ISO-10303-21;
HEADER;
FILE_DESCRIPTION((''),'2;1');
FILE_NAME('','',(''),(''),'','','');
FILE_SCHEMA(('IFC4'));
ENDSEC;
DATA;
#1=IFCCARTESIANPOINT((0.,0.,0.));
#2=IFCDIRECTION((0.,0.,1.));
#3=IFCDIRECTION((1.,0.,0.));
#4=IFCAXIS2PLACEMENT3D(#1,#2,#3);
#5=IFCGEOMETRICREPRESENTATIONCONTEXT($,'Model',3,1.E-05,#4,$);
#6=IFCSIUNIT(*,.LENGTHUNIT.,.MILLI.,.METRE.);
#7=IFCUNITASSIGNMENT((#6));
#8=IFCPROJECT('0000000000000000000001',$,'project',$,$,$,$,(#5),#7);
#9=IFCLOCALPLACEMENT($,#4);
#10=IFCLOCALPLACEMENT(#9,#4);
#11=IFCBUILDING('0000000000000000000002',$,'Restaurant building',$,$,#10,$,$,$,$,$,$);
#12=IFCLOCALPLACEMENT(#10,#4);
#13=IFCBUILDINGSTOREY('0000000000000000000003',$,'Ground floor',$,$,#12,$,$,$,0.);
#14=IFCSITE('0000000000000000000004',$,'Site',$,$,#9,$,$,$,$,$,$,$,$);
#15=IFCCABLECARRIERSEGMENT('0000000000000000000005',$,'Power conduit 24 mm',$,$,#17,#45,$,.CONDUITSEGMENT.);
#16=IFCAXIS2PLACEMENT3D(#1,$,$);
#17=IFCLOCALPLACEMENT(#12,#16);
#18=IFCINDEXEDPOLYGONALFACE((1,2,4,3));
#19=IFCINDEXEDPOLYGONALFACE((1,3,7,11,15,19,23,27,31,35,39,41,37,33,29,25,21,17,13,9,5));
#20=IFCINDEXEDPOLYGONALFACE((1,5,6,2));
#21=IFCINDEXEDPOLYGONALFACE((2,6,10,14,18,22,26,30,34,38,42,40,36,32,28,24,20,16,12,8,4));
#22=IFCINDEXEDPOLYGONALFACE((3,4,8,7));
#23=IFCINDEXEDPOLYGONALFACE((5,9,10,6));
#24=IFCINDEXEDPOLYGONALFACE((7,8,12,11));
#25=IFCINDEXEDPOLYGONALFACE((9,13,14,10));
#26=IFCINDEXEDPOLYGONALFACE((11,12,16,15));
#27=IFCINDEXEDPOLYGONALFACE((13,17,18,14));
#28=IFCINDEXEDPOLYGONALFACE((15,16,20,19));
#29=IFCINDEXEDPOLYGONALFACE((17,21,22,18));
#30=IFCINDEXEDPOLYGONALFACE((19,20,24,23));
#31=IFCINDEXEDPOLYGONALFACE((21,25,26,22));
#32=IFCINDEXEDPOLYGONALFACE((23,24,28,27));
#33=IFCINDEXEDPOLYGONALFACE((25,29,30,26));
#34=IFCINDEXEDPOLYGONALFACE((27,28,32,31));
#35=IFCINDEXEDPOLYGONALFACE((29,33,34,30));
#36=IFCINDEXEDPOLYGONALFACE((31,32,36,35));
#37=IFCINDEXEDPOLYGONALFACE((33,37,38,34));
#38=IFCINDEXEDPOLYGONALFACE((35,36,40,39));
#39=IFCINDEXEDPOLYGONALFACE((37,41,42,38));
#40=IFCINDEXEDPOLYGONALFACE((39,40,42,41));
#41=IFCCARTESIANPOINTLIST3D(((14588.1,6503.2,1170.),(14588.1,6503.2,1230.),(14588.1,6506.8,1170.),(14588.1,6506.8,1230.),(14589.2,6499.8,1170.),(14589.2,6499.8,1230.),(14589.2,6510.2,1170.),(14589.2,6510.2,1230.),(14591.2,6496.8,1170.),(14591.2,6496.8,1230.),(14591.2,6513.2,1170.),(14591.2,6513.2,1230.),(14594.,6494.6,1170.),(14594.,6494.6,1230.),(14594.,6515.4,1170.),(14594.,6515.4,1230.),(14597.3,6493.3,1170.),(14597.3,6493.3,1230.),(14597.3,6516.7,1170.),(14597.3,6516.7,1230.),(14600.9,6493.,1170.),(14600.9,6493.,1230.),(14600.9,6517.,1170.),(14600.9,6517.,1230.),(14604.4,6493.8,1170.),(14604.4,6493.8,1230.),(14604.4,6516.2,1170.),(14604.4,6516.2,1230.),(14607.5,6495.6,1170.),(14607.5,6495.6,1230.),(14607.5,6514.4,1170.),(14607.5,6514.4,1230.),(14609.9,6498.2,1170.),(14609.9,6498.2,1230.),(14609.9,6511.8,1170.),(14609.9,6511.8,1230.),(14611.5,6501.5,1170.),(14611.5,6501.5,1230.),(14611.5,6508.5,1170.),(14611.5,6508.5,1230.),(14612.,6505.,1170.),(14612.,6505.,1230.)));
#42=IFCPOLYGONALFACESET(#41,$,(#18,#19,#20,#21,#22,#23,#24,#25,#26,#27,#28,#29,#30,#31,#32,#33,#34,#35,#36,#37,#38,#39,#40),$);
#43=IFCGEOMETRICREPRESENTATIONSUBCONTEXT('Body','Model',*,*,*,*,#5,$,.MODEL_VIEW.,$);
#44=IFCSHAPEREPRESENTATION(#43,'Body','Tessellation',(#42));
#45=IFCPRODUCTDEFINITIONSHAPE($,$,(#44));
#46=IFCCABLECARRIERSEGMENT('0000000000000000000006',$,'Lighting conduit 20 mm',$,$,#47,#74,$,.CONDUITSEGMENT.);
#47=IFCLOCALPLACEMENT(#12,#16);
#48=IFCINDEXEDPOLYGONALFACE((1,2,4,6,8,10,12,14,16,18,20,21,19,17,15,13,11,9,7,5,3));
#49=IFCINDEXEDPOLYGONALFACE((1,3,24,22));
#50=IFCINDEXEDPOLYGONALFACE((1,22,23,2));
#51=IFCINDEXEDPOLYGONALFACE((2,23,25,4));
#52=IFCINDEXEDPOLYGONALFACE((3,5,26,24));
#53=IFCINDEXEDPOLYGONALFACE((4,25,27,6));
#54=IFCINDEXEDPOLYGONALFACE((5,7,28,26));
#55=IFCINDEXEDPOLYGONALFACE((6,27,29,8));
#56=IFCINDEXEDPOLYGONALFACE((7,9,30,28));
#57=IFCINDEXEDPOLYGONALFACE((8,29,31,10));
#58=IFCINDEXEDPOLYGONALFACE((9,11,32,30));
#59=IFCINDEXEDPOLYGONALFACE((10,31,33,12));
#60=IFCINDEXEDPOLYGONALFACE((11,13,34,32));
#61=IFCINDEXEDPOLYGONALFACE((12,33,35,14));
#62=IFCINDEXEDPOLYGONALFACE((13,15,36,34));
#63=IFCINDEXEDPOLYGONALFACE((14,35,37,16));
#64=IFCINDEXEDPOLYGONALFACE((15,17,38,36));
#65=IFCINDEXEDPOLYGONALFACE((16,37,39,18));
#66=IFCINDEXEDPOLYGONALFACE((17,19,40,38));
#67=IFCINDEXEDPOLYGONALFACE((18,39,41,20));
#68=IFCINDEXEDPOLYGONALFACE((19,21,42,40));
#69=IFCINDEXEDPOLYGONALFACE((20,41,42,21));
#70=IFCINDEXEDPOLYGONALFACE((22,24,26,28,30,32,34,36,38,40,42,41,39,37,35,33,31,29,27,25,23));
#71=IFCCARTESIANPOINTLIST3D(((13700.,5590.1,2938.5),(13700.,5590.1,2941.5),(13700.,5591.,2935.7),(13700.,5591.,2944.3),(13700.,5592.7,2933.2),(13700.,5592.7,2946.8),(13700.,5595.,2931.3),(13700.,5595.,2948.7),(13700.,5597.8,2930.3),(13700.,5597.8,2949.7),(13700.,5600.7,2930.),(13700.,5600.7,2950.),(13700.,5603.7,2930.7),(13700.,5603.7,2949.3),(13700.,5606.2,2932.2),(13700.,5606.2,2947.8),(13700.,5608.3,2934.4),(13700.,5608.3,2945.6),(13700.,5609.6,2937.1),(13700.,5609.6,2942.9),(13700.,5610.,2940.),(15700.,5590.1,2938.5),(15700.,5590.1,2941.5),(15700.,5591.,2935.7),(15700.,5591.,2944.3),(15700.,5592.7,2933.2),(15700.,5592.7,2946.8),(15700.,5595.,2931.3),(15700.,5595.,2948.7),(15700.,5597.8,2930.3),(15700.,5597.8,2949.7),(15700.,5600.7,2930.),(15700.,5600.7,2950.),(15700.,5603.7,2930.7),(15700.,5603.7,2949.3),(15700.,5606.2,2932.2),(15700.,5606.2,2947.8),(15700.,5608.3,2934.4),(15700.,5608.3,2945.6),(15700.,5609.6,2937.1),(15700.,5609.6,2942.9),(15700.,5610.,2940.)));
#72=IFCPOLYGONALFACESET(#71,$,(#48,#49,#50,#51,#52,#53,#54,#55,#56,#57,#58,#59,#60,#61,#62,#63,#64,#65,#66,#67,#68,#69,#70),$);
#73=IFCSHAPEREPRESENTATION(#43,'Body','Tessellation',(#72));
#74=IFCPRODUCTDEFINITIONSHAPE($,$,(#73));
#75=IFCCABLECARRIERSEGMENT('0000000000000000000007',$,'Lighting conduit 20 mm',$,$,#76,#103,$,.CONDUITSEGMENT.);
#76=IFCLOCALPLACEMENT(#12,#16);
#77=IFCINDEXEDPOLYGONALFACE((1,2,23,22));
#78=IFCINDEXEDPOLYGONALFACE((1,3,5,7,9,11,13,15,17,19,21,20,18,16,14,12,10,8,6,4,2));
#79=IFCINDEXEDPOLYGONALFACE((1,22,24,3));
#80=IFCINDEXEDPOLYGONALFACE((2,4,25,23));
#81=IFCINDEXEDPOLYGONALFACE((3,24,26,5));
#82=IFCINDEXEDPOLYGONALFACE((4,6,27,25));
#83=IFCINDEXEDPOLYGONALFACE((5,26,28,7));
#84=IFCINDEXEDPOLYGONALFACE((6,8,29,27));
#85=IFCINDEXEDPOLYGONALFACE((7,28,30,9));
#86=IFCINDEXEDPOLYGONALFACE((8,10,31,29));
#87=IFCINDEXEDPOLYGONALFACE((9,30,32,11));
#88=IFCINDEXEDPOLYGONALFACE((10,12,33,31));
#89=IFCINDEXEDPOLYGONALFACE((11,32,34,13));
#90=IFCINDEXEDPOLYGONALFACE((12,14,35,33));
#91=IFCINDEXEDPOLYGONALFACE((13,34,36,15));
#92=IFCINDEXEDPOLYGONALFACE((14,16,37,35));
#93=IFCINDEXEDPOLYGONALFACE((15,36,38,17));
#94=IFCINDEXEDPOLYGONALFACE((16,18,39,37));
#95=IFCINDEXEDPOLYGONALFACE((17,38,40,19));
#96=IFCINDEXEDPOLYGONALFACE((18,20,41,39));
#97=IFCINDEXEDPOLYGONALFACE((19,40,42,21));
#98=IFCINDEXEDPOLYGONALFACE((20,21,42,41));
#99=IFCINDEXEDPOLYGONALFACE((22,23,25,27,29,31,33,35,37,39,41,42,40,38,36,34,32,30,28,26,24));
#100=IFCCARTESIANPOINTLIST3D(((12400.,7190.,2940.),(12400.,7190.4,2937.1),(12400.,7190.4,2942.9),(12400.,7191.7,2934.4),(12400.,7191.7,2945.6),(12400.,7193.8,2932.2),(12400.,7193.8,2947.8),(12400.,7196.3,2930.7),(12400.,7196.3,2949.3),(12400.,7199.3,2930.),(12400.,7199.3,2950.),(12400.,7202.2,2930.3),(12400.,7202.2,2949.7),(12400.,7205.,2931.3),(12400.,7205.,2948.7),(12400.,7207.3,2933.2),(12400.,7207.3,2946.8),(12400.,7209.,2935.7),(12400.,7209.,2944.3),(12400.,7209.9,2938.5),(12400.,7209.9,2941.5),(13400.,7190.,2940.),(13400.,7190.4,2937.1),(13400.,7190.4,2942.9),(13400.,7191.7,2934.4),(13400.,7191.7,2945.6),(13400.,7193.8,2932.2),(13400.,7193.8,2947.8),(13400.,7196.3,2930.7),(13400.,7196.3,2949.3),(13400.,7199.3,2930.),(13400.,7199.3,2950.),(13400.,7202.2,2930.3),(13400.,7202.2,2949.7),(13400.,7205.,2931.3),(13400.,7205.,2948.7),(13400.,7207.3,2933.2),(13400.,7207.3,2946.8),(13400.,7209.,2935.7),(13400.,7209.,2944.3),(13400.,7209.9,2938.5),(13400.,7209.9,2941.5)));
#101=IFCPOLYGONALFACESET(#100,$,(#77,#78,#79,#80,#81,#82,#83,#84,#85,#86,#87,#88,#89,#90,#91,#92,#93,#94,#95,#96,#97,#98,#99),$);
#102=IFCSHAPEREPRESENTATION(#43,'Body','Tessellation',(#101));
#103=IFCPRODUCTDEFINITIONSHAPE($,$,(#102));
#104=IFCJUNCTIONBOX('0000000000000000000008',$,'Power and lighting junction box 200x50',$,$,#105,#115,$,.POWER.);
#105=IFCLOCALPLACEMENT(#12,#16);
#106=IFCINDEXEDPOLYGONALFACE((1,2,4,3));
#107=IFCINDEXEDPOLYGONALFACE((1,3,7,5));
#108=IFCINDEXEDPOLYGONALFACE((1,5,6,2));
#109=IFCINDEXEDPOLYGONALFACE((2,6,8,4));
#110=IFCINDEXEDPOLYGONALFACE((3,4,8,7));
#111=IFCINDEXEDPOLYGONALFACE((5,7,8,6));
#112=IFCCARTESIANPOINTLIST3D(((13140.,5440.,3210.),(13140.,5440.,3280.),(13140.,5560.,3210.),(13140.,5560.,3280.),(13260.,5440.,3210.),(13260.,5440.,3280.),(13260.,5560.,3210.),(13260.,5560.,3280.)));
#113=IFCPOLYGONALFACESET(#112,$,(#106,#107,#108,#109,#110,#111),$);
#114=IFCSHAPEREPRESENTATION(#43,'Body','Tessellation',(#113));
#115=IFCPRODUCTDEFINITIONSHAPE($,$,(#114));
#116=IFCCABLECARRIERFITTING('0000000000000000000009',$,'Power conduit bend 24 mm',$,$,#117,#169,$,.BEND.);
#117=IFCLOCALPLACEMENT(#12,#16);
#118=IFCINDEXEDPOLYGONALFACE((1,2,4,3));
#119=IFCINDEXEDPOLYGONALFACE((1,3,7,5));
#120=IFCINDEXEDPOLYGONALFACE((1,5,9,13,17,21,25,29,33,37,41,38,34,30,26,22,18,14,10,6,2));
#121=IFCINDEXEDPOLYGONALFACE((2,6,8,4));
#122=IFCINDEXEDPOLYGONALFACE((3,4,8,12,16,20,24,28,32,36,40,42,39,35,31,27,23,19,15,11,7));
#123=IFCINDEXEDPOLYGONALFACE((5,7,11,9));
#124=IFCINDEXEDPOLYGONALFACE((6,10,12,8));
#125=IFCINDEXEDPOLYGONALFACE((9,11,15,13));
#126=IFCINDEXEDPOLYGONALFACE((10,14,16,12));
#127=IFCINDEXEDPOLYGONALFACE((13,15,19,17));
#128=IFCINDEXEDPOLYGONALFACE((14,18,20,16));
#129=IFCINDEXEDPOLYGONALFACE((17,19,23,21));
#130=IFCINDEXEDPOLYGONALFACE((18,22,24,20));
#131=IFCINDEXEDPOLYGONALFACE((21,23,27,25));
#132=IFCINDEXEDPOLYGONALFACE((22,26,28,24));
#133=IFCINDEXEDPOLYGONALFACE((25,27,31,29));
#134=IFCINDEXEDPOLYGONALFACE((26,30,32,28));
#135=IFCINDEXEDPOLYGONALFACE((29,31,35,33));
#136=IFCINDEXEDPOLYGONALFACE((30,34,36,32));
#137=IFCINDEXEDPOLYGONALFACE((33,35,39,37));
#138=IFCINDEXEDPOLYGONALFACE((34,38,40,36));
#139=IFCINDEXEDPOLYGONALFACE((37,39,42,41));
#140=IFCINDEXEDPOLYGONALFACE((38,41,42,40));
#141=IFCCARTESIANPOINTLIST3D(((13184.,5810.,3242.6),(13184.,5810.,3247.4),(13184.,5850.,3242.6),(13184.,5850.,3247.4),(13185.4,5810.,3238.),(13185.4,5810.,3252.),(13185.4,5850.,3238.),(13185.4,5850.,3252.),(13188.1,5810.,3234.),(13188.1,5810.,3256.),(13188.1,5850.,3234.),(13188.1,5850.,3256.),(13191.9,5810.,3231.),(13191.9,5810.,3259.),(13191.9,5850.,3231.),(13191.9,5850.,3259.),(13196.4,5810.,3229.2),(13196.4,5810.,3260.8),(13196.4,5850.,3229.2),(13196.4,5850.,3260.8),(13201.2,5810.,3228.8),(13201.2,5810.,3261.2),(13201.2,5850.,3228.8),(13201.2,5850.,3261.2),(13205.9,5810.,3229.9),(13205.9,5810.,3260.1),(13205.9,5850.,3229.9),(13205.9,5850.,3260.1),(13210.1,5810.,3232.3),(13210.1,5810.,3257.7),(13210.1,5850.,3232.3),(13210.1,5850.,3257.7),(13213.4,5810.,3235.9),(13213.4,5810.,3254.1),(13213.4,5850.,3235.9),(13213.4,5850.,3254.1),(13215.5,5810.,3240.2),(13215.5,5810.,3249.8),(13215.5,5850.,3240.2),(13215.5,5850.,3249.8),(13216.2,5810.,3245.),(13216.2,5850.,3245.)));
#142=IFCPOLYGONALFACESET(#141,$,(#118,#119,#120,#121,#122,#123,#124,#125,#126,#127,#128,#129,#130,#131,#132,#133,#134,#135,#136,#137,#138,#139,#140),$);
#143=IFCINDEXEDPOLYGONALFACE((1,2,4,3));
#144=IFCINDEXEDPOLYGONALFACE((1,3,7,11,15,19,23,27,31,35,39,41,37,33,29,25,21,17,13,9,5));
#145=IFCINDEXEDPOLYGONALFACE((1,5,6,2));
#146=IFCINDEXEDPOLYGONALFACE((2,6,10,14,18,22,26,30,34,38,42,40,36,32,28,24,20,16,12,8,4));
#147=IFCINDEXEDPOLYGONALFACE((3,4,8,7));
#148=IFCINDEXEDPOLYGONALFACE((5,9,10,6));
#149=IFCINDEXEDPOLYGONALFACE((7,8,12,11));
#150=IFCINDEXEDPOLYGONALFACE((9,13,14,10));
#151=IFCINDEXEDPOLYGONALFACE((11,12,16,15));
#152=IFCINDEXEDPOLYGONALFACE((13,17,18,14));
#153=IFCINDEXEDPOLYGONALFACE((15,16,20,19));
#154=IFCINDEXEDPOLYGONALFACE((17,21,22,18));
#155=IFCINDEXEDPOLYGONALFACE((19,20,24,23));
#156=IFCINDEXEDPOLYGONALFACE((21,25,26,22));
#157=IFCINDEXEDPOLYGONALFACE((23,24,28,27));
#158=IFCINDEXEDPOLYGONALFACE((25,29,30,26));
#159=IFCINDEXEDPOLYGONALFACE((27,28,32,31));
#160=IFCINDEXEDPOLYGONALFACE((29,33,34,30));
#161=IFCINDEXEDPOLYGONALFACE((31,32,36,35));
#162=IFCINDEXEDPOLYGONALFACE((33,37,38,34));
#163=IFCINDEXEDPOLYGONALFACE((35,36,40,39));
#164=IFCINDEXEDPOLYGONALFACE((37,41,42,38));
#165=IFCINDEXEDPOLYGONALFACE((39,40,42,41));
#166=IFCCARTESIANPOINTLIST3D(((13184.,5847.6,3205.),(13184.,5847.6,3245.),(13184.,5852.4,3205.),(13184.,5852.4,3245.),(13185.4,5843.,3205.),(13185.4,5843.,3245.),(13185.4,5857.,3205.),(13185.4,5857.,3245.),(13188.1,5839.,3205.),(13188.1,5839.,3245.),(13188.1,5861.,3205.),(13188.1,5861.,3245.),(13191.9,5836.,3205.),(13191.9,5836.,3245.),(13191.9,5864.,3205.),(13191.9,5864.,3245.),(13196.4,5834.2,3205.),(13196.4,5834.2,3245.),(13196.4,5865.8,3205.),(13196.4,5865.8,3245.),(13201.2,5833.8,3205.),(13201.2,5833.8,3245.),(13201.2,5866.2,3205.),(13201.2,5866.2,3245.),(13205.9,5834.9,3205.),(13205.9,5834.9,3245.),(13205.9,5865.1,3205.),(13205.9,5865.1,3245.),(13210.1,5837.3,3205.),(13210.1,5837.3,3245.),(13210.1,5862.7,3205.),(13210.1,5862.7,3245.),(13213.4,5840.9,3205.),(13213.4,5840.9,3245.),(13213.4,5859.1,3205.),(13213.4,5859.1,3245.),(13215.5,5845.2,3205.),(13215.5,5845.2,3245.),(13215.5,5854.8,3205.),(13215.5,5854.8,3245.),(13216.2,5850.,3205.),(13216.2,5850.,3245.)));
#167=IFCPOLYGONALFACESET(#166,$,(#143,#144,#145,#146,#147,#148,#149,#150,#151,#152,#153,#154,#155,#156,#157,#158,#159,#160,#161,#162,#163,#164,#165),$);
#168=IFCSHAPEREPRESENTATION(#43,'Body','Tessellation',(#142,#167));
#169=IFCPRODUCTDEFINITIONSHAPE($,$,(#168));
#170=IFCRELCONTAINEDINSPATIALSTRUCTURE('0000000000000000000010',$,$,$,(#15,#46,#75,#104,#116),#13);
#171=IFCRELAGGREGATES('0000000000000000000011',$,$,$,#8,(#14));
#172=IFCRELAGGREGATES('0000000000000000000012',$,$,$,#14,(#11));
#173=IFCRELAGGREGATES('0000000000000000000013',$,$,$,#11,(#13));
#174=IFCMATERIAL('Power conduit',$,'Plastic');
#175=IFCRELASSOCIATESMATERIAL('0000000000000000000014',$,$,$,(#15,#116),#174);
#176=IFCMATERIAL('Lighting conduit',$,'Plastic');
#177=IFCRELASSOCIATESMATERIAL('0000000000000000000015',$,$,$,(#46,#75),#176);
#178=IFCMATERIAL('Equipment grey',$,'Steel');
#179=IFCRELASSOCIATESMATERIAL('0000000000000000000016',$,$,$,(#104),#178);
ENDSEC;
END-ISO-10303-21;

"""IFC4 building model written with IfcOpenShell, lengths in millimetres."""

from ifc_helpers import new_model, si_unit, frame, origin, origin_with_axes, origin_2d, place, context, subcontext, project, spatial, rectangle, circle, extrude, material, element, save


model = new_model("IFC4")

# Units and contexts
model_context = context("Model", 3, precision=1e-05, world=origin_with_axes())
body_context = subcontext(model_context, "Body", "Model", "MODEL_VIEW")
ifc_project = project(units=[si_unit("LENGTHUNIT", "METRE", prefix="MILLI")], contexts=[model_context])

# Site, building, storey
site_placement = place(None, origin_with_axes())
site = spatial("IfcSite", under=ifc_project, at=site_placement, Name="Site")
building_placement = place(site_placement, origin_with_axes())
building = spatial("IfcBuilding", under=site, at=building_placement, Name="Restaurant building")
storey_placement = place(building_placement, origin_with_axes())
storey = spatial("IfcBuildingStorey", under=building, at=storey_placement, Name="Ground floor", Elevation=0.0)

# Cable carrier segments
ifc_material_1 = material(Name="Power conduit", Category="Plastic")
cable_carrier_segment_1_placement = place(storey_placement, frame((14600.0, 6505.0, 1170.0)))
element("IfcCableCarrierSegment", 1, at=cable_carrier_segment_1_placement, inside=storey, material=ifc_material_1, Name="Power conduit 24 mm", PredefinedType="CONDUITSEGMENT", context=body_context, shape_type="SweptSolid", body=[
    extrude(circle(Radius=12.0, at=origin_2d()), origin(), (0.0, 0.0, 1.0), 60.0),
])
ifc_material_2 = material(Name="Lighting conduit", Category="Plastic")
cable_carrier_segment_2_placement = place(storey_placement, frame((13700.0, 5600.0, 2940.0)))
element("IfcCableCarrierSegment", 2, at=cable_carrier_segment_2_placement, inside=storey, material=ifc_material_2, Name="Lighting conduit 20 mm", PredefinedType="CONDUITSEGMENT", context=body_context, shape_type="SweptSolid", body=[
    extrude(circle(Radius=10.0, at=origin_2d()), frame((0.0, 0.0, 0.0), z_axis=(1.0, 0.0, 0.0), x_axis=(0.0, 1.0, 0.0)), (0.0, 0.0, 1.0), 2000.0),
])
cable_carrier_segment_3_placement = place(storey_placement, frame((13400.0, 7200.0, 2940.0)))
element("IfcCableCarrierSegment", 3, at=cable_carrier_segment_3_placement, inside=storey, material=ifc_material_2, Name="Lighting conduit 20 mm", PredefinedType="CONDUITSEGMENT", context=body_context, shape_type="SweptSolid", body=[
    extrude(circle(Radius=10.0, at=origin_2d()), frame((0.0, 0.0, 0.0), z_axis=(-1.0, 0.0, 0.0), x_axis=(0.0, -1.0, 0.0)), (0.0, 0.0, 1.0), 1000.0),
])

# Junction box
ifc_material_3 = material(Name="Equipment grey", Category="Steel")
junction_box_placement = place(storey_placement, frame((13200.0, 5500.0, 3245.0)))
element("IfcJunctionBox", 4, at=junction_box_placement, inside=storey, material=ifc_material_3, Name="Power and lighting junction box 200x50", PredefinedType="POWER", context=body_context, shape_type="SweptSolid", body=[
    extrude(rectangle(XDim=120.0, YDim=120.0, at=origin_2d()), frame((0.0, 0.0, -35.0)), (0.0, 0.0, 1.0), 70.0),
])

# Cable carrier fitting
cable_carrier_fitting_1_placement = place(storey_placement, frame((13200.0, 5850.0, 3245.0)))
element("IfcCableCarrierFitting", 5, at=cable_carrier_fitting_1_placement, inside=storey, material=ifc_material_1, Name="Power conduit bend 24 mm", PredefinedType="BEND", context=body_context, shape_type="SweptSolid", body=[
    extrude(circle(Radius=16.2, at=origin_2d()), frame((0.0, 0.0, 0.0), z_axis=(0.0, -1.0, 0.0), x_axis=(1.0, 0.0, 0.0)), (0.0, 0.0, 1.0), 40.0),
    extrude(circle(Radius=16.2, at=origin_2d()), frame((0.0, 0.0, 0.0), z_axis=(0.0, 0.0, -1.0), x_axis=(1.0, 0.0, 0.0)), (0.0, 0.0, 1.0), 40.0),
])

save(model, "model.ifc")
